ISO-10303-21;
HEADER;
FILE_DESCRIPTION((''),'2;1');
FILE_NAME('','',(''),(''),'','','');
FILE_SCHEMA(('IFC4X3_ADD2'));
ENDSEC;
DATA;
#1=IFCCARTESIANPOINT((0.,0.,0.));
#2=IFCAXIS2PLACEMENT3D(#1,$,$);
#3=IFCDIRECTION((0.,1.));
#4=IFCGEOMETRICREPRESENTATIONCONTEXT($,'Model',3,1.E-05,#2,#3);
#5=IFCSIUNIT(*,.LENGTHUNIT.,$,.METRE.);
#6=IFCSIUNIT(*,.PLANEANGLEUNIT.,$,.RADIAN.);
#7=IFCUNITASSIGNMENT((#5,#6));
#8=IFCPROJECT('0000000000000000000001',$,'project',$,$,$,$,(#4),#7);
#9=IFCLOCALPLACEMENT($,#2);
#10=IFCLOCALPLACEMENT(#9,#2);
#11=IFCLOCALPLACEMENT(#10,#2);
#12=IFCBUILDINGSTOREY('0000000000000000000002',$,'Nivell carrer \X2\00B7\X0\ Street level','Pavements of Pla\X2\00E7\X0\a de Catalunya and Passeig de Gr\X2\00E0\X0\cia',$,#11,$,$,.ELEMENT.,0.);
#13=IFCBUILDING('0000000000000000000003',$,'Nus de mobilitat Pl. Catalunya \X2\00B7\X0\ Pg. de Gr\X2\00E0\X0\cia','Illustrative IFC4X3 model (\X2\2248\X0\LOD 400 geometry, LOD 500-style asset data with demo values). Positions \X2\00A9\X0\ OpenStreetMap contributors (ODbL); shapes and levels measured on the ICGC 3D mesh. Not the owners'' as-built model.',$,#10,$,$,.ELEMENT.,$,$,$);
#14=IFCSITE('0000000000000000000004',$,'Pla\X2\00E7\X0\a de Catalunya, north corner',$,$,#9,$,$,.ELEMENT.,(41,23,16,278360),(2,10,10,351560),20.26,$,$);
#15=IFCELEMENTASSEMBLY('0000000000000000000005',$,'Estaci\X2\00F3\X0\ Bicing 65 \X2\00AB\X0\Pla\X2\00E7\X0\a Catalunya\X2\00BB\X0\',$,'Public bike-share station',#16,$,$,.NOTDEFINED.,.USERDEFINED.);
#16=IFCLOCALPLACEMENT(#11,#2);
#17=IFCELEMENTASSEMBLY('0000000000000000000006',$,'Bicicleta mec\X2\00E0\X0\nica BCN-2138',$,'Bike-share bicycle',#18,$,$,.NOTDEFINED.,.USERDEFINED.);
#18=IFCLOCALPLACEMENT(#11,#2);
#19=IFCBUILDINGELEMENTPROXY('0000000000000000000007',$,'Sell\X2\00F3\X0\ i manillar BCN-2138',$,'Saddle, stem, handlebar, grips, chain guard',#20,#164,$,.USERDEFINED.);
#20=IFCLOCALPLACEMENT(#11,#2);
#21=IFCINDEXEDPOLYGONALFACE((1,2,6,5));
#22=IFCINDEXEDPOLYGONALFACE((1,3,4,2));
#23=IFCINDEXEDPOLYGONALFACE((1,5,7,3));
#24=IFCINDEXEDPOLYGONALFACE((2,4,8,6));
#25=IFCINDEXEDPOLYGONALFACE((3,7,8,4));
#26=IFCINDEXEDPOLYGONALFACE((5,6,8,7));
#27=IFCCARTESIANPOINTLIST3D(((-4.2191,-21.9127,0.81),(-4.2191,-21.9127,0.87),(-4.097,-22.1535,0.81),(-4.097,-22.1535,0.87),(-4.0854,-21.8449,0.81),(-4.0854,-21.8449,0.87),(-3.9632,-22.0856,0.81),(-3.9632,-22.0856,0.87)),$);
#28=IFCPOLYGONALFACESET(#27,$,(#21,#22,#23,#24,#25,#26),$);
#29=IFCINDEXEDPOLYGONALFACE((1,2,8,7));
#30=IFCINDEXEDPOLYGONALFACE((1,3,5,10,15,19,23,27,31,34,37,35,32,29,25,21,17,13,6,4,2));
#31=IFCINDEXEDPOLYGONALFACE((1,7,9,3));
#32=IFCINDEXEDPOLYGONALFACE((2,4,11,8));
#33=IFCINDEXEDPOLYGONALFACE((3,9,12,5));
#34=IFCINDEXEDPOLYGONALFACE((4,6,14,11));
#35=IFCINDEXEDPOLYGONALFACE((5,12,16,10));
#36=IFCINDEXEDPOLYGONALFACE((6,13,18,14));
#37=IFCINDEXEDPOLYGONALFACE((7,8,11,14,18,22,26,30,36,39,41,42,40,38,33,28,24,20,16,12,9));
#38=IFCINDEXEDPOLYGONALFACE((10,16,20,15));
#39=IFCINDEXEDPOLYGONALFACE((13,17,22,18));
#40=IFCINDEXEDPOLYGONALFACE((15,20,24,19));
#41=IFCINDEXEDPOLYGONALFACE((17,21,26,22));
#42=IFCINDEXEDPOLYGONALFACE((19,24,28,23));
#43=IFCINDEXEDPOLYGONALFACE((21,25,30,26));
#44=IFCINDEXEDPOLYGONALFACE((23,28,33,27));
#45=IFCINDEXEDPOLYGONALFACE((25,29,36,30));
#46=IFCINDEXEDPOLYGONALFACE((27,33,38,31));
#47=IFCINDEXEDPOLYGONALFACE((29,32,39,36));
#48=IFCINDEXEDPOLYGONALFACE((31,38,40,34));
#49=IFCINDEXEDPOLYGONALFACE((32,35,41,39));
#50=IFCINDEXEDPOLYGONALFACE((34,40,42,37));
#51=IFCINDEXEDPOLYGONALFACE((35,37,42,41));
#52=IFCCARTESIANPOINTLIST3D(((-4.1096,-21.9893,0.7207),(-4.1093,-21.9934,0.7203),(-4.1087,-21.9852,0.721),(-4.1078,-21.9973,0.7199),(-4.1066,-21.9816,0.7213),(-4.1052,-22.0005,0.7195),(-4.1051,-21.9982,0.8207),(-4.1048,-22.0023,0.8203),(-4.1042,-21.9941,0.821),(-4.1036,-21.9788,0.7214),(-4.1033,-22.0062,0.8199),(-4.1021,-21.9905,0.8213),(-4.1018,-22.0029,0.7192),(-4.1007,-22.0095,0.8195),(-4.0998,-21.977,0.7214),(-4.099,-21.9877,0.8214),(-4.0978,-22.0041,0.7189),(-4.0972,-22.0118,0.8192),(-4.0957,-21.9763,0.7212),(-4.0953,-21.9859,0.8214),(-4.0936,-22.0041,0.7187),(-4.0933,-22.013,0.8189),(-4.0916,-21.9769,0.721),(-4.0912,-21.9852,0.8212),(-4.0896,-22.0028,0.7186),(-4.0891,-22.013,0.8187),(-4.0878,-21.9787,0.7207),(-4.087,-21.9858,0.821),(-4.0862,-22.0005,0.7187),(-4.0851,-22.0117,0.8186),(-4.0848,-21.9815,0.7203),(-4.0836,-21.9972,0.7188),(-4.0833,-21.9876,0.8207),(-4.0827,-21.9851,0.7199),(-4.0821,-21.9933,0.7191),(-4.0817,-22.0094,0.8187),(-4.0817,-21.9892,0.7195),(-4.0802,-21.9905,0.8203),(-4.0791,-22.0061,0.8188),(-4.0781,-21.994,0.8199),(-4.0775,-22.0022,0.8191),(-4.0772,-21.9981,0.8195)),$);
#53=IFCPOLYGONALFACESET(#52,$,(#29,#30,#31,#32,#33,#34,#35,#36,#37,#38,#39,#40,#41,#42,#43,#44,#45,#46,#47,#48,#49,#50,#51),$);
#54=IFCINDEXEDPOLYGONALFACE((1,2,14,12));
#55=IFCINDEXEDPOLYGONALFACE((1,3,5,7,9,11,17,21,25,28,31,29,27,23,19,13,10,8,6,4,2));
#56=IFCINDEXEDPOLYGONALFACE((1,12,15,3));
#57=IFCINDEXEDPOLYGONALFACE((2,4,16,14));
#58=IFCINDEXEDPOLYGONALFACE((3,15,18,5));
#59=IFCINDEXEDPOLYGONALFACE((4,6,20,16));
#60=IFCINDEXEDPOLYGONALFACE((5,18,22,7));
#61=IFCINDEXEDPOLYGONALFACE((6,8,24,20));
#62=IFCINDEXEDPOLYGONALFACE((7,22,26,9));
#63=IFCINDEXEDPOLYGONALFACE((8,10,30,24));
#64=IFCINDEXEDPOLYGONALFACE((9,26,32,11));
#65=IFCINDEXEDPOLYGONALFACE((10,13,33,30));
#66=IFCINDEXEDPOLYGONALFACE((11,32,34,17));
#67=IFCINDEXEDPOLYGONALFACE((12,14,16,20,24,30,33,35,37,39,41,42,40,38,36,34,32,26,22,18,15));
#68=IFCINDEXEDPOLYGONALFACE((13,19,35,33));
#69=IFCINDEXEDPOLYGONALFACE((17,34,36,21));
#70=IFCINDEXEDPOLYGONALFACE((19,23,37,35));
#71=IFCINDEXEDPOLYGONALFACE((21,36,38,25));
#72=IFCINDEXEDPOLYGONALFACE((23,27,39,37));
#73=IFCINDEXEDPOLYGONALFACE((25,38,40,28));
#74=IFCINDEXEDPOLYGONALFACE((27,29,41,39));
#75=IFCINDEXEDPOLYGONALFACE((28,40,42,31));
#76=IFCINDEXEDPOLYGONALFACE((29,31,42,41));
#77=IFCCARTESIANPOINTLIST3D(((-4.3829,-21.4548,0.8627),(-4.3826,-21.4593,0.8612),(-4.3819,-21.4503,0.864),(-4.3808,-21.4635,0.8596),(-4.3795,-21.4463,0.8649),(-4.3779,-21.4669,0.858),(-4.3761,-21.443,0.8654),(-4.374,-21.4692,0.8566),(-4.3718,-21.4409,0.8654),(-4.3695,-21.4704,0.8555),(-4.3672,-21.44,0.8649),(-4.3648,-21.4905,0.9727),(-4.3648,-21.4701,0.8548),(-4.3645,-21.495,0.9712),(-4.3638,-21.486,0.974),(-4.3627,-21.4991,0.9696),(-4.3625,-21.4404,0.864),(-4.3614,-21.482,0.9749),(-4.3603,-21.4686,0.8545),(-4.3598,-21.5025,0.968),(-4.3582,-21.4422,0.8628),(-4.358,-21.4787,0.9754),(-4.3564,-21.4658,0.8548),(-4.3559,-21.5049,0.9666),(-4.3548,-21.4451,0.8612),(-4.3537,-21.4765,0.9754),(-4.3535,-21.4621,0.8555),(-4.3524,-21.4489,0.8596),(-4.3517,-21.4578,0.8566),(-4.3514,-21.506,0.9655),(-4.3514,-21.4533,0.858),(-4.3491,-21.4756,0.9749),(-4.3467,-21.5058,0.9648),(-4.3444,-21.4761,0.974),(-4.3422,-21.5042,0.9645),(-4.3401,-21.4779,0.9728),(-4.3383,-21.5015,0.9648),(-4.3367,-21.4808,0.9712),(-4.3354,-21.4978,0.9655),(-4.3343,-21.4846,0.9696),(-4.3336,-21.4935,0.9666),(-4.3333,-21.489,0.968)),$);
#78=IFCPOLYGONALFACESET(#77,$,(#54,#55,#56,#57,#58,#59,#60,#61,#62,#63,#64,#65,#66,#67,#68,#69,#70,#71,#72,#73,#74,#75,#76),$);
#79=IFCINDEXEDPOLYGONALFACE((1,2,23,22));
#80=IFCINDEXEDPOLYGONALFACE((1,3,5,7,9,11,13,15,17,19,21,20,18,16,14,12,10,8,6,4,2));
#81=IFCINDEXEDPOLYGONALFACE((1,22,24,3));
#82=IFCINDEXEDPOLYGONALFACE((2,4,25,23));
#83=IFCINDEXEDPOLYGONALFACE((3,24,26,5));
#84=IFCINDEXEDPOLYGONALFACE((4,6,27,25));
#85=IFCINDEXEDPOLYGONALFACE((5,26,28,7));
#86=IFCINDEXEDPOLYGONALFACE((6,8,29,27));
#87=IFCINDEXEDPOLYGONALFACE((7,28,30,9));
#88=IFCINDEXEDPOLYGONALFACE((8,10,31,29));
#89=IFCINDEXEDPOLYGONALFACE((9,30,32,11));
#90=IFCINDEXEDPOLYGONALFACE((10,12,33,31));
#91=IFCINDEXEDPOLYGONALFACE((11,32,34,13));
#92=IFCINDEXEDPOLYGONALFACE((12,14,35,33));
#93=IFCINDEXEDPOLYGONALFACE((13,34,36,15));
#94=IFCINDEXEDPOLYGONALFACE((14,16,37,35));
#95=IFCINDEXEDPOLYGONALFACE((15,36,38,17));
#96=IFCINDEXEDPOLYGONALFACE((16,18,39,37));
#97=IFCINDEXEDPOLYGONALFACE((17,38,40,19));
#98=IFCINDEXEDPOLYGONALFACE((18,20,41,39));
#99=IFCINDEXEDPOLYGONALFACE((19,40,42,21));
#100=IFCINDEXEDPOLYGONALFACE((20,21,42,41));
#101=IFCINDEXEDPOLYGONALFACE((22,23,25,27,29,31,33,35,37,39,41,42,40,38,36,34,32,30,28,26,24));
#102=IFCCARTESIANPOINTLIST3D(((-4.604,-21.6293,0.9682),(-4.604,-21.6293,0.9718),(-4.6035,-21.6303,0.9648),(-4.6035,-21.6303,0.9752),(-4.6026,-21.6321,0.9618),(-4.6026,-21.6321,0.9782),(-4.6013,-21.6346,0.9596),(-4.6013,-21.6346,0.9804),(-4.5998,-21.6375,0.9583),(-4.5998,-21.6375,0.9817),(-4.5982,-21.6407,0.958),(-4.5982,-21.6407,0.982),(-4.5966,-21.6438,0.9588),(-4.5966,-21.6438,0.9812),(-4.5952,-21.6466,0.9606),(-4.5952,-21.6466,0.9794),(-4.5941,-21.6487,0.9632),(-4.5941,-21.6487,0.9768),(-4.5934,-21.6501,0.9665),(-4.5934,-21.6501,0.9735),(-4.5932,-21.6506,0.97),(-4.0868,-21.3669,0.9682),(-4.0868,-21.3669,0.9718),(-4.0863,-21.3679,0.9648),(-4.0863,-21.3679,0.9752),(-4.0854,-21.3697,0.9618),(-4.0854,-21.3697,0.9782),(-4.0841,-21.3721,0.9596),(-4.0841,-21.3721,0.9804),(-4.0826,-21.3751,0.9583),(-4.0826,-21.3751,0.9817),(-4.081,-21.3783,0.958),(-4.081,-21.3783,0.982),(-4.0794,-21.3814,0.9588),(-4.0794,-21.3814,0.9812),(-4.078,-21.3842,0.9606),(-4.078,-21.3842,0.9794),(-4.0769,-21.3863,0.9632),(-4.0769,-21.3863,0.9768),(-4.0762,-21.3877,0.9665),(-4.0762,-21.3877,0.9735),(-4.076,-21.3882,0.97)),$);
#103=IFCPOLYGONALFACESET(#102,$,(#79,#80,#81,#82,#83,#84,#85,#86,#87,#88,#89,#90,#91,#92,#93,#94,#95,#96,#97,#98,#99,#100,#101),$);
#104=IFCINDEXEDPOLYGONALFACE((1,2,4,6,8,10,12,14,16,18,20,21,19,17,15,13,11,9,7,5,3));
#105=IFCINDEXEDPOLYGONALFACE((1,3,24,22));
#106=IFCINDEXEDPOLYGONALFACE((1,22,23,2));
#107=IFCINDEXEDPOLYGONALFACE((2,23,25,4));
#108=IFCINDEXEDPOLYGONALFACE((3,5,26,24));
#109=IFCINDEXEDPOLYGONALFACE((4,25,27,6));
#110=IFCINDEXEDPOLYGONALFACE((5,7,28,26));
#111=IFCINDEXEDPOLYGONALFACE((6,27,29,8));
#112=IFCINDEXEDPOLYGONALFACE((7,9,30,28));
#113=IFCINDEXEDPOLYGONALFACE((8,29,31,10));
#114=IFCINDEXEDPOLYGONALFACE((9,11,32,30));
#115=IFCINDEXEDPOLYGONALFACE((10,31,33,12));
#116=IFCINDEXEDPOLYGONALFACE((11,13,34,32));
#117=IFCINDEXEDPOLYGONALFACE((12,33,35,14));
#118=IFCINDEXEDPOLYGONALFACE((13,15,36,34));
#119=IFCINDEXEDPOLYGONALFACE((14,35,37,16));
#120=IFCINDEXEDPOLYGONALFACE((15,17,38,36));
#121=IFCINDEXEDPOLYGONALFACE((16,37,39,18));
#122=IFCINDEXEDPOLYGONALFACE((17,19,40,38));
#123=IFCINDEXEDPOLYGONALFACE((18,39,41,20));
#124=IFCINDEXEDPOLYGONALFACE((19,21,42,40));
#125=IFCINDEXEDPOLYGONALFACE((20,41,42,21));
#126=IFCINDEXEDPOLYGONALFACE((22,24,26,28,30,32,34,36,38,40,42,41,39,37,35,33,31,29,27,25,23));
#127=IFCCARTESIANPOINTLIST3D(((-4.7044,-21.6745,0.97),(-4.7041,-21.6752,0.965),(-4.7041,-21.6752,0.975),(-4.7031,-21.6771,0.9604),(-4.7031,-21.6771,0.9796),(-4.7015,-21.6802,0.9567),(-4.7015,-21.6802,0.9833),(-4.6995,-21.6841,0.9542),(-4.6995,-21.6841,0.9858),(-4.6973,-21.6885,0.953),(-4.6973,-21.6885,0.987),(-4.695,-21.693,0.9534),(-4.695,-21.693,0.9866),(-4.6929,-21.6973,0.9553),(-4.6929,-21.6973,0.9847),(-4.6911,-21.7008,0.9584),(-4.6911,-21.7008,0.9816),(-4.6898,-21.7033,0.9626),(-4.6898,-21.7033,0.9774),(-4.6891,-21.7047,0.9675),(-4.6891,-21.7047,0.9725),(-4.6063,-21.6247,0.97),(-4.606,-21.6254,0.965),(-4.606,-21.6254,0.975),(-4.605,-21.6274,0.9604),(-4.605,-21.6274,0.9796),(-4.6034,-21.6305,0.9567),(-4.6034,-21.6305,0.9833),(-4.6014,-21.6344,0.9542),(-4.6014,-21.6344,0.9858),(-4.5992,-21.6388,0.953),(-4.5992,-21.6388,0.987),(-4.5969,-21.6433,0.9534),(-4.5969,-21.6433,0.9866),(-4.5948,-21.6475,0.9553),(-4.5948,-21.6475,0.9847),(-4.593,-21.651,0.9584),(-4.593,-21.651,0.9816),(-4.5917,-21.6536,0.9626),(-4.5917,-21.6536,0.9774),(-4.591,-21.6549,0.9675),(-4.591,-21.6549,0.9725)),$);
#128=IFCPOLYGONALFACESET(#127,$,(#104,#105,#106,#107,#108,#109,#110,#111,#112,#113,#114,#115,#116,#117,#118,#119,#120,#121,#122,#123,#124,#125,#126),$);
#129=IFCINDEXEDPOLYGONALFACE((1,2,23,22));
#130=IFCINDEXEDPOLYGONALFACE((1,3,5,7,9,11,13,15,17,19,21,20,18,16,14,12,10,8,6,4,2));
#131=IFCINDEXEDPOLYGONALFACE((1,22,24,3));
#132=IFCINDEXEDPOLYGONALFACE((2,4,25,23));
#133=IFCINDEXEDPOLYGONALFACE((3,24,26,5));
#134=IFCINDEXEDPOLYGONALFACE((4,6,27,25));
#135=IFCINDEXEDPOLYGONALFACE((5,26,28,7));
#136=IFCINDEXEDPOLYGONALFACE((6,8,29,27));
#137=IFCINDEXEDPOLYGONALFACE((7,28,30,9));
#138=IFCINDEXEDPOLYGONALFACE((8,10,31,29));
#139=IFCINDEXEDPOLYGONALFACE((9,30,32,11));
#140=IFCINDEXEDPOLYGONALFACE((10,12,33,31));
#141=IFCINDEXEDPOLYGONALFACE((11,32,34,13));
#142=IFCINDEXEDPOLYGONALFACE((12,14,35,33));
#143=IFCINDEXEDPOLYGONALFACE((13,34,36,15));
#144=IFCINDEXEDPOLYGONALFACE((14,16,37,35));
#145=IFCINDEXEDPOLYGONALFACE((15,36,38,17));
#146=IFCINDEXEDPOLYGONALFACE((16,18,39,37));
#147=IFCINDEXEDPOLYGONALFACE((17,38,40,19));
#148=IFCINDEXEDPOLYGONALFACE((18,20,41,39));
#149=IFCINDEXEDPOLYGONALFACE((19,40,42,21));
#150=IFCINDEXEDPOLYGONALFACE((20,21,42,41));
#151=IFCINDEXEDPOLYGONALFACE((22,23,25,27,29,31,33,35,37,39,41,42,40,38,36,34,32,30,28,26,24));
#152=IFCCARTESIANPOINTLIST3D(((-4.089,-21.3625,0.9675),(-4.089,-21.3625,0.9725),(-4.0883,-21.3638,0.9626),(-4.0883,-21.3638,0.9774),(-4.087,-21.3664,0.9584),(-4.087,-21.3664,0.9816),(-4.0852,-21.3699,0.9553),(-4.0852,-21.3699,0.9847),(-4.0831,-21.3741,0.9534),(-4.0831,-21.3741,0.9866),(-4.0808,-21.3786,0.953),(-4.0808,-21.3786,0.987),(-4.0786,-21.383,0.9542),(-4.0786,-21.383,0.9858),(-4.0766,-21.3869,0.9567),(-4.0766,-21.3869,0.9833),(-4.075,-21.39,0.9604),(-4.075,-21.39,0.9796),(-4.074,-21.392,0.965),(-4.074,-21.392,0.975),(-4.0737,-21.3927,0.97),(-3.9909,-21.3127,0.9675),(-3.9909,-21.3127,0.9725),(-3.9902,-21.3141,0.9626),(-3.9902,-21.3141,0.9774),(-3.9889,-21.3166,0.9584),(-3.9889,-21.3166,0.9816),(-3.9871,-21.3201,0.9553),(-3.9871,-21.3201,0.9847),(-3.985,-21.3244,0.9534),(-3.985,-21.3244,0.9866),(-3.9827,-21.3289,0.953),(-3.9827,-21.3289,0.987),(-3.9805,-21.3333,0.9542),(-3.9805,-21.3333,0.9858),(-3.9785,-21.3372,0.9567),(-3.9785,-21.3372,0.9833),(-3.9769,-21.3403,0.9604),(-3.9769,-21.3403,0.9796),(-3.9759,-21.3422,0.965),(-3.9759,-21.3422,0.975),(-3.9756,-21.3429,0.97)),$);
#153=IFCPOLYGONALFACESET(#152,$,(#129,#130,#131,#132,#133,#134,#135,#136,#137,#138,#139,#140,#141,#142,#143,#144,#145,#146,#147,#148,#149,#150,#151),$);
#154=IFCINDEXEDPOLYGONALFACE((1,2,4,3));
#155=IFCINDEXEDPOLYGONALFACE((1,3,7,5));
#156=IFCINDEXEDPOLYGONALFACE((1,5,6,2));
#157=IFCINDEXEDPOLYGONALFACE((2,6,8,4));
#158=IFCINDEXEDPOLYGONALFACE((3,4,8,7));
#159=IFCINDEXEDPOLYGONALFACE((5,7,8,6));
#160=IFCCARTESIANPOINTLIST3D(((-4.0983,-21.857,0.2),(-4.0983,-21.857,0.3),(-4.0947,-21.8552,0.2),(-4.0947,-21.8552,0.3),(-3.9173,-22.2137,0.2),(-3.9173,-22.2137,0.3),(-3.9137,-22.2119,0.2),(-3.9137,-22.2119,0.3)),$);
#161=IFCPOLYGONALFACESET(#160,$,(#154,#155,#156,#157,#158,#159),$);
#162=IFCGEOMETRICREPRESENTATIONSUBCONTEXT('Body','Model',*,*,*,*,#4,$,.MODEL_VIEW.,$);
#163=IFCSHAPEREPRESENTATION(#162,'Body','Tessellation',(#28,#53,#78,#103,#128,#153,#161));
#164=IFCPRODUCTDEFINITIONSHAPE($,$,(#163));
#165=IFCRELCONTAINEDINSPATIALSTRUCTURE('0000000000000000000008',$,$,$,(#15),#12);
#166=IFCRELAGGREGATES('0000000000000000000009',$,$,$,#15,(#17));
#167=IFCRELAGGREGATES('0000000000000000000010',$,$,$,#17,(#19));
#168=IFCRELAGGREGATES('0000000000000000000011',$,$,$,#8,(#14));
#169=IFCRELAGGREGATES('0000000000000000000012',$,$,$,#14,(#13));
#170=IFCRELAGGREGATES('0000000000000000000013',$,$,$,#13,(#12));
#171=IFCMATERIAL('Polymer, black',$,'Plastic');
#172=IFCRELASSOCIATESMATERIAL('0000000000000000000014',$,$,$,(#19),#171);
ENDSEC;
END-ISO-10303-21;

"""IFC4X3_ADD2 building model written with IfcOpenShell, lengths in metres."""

from ifc_helpers import new_model, si_unit, direction, frame, origin, origin_2d_with_axis, place, context, subcontext, project, spatial, rectangle, circle, extrude, material, element, aggregate, save


model = new_model("IFC4X3_ADD2")

# Units and contexts
model_context = context("Model", 3, precision=1e-05, world=origin(), true_north=direction((0.0, 1.0)))
body_context = subcontext(model_context, "Body", "Model", "MODEL_VIEW")
ifc_project = project(units=[si_unit("LENGTHUNIT", "METRE"), si_unit("PLANEANGLEUNIT", "RADIAN")], contexts=[model_context])

# Site, building, storey
site_placement = place(None, origin())
site = spatial("IfcSite", under=ifc_project, at=site_placement, Name="Plaça de Catalunya, north corner", CompositionType="ELEMENT", RefLatitude=(41, 23, 16, 278360), RefLongitude=(2, 10, 10, 351560), RefElevation=20.26)
building_placement = place(site_placement, origin())
building = spatial("IfcBuilding", under=site, at=building_placement, Name="Nus de mobilitat Pl. Catalunya · Pg. de Gràcia", Description="Illustrative IFC4X3 model (≈LOD 400 geometry, LOD 500-style asset data with demo values). Positions © OpenStreetMap contributors (ODbL); shapes and levels measured on the ICGC 3D mesh. Not the owners' as-built model.", CompositionType="ELEMENT")
storey_placement = place(building_placement, origin())
storey = spatial("IfcBuildingStorey", under=building, at=storey_placement, Name="Nivell carrer · Street level", Description="Pavements of Plaça de Catalunya and Passeig de Gràcia", CompositionType="ELEMENT", Elevation=0.0)

# Element assemblies, building element proxy
assembly_1_placement = place(building_placement, origin())
assembly_1 = element("IfcElementAssembly", 1, at=assembly_1_placement, inside=storey, Name="Estació Bicing 65 «Plaça Catalunya»", ObjectType="Public bike-share station", AssemblyPlace="NOTDEFINED", PredefinedType="USERDEFINED")
ifc_material_1 = material(Name="Polymer, black", Category="Plastic")
assembly_2_placement = place(building_placement, origin())
assembly_2 = element("IfcElementAssembly", 2, at=assembly_2_placement, Name="Bicicleta mecànica BCN-2138", ObjectType="Bike-share bicycle", AssemblyPlace="NOTDEFINED", PredefinedType="USERDEFINED")
aggregate(assembly_1, [assembly_2])
proxy_1_placement = place(building_placement, origin())
proxy_1 = element("IfcBuildingElementProxy", 3, at=proxy_1_placement, material=ifc_material_1, Name="Selló i manillar BCN-2138", ObjectType="Saddle, stem, handlebar, grips, chain guard", PredefinedType="USERDEFINED", context=body_context, shape_type="SweptSolid", body=[
    extrude(rectangle(XDim=0.27, YDim=0.15, at=origin_2d_with_axis()), frame((-4.0912, -21.9992, 0.87), z_axis=(0.0, 0.0, -1.0), x_axis=(-0.452435, 0.891798, 0.0)), (0.0, 0.0, 1.0), 0.06),
    extrude(circle(Radius=0.014, at=origin_2d_with_axis()), frame((-4.0957, -21.9903, 0.72), z_axis=(0.045019, -0.088737, 0.995037), x_axis=(0.0, 0.996047, 0.088827)), (0.0, 0.0, 1.0), 0.1005),
    extrude(circle(Radius=0.016, at=origin_2d_with_axis()), frame((-4.3672, -21.4552, 0.86), z_axis=(0.154616, -0.304766, 0.939793), x_axis=(0.0, 0.951232, 0.308475)), (0.0, 0.0, 1.0), 0.117),
    extrude(circle(Radius=0.012, at=origin_2d_with_axis()), frame((-4.5986, -21.6399, 0.97), z_axis=(0.891798, 0.452435, 0.0), x_axis=(0.452435, -0.891798, 0.0)), (0.0, 0.0, 1.0), 0.58),
    extrude(circle(Radius=0.017, at=origin_2d_with_axis()), frame((-4.5986, -21.6399, 0.97), z_axis=(-0.891798, -0.452435, 0.0), x_axis=(-0.452435, 0.891798, 0.0)), (0.0, 0.0, 1.0), 0.11),
    extrude(circle(Radius=0.017, at=origin_2d_with_axis()), frame((-4.0814, -21.3775, 0.97), z_axis=(0.891798, 0.452435, 0.0), x_axis=(0.452435, -0.891798, 0.0)), (0.0, 0.0, 1.0), 0.11),
    extrude(rectangle(XDim=0.4, YDim=0.1, at=origin_2d_with_axis()), frame((-4.0078, -22.0354, 0.25), z_axis=(0.891798, 0.452435, 0.0), x_axis=(-0.452435, 0.891798, 0.0)), (0.0, 0.0, 1.0), 0.004),
])
aggregate(assembly_2, [proxy_1])

save(model, "model.ifc")
